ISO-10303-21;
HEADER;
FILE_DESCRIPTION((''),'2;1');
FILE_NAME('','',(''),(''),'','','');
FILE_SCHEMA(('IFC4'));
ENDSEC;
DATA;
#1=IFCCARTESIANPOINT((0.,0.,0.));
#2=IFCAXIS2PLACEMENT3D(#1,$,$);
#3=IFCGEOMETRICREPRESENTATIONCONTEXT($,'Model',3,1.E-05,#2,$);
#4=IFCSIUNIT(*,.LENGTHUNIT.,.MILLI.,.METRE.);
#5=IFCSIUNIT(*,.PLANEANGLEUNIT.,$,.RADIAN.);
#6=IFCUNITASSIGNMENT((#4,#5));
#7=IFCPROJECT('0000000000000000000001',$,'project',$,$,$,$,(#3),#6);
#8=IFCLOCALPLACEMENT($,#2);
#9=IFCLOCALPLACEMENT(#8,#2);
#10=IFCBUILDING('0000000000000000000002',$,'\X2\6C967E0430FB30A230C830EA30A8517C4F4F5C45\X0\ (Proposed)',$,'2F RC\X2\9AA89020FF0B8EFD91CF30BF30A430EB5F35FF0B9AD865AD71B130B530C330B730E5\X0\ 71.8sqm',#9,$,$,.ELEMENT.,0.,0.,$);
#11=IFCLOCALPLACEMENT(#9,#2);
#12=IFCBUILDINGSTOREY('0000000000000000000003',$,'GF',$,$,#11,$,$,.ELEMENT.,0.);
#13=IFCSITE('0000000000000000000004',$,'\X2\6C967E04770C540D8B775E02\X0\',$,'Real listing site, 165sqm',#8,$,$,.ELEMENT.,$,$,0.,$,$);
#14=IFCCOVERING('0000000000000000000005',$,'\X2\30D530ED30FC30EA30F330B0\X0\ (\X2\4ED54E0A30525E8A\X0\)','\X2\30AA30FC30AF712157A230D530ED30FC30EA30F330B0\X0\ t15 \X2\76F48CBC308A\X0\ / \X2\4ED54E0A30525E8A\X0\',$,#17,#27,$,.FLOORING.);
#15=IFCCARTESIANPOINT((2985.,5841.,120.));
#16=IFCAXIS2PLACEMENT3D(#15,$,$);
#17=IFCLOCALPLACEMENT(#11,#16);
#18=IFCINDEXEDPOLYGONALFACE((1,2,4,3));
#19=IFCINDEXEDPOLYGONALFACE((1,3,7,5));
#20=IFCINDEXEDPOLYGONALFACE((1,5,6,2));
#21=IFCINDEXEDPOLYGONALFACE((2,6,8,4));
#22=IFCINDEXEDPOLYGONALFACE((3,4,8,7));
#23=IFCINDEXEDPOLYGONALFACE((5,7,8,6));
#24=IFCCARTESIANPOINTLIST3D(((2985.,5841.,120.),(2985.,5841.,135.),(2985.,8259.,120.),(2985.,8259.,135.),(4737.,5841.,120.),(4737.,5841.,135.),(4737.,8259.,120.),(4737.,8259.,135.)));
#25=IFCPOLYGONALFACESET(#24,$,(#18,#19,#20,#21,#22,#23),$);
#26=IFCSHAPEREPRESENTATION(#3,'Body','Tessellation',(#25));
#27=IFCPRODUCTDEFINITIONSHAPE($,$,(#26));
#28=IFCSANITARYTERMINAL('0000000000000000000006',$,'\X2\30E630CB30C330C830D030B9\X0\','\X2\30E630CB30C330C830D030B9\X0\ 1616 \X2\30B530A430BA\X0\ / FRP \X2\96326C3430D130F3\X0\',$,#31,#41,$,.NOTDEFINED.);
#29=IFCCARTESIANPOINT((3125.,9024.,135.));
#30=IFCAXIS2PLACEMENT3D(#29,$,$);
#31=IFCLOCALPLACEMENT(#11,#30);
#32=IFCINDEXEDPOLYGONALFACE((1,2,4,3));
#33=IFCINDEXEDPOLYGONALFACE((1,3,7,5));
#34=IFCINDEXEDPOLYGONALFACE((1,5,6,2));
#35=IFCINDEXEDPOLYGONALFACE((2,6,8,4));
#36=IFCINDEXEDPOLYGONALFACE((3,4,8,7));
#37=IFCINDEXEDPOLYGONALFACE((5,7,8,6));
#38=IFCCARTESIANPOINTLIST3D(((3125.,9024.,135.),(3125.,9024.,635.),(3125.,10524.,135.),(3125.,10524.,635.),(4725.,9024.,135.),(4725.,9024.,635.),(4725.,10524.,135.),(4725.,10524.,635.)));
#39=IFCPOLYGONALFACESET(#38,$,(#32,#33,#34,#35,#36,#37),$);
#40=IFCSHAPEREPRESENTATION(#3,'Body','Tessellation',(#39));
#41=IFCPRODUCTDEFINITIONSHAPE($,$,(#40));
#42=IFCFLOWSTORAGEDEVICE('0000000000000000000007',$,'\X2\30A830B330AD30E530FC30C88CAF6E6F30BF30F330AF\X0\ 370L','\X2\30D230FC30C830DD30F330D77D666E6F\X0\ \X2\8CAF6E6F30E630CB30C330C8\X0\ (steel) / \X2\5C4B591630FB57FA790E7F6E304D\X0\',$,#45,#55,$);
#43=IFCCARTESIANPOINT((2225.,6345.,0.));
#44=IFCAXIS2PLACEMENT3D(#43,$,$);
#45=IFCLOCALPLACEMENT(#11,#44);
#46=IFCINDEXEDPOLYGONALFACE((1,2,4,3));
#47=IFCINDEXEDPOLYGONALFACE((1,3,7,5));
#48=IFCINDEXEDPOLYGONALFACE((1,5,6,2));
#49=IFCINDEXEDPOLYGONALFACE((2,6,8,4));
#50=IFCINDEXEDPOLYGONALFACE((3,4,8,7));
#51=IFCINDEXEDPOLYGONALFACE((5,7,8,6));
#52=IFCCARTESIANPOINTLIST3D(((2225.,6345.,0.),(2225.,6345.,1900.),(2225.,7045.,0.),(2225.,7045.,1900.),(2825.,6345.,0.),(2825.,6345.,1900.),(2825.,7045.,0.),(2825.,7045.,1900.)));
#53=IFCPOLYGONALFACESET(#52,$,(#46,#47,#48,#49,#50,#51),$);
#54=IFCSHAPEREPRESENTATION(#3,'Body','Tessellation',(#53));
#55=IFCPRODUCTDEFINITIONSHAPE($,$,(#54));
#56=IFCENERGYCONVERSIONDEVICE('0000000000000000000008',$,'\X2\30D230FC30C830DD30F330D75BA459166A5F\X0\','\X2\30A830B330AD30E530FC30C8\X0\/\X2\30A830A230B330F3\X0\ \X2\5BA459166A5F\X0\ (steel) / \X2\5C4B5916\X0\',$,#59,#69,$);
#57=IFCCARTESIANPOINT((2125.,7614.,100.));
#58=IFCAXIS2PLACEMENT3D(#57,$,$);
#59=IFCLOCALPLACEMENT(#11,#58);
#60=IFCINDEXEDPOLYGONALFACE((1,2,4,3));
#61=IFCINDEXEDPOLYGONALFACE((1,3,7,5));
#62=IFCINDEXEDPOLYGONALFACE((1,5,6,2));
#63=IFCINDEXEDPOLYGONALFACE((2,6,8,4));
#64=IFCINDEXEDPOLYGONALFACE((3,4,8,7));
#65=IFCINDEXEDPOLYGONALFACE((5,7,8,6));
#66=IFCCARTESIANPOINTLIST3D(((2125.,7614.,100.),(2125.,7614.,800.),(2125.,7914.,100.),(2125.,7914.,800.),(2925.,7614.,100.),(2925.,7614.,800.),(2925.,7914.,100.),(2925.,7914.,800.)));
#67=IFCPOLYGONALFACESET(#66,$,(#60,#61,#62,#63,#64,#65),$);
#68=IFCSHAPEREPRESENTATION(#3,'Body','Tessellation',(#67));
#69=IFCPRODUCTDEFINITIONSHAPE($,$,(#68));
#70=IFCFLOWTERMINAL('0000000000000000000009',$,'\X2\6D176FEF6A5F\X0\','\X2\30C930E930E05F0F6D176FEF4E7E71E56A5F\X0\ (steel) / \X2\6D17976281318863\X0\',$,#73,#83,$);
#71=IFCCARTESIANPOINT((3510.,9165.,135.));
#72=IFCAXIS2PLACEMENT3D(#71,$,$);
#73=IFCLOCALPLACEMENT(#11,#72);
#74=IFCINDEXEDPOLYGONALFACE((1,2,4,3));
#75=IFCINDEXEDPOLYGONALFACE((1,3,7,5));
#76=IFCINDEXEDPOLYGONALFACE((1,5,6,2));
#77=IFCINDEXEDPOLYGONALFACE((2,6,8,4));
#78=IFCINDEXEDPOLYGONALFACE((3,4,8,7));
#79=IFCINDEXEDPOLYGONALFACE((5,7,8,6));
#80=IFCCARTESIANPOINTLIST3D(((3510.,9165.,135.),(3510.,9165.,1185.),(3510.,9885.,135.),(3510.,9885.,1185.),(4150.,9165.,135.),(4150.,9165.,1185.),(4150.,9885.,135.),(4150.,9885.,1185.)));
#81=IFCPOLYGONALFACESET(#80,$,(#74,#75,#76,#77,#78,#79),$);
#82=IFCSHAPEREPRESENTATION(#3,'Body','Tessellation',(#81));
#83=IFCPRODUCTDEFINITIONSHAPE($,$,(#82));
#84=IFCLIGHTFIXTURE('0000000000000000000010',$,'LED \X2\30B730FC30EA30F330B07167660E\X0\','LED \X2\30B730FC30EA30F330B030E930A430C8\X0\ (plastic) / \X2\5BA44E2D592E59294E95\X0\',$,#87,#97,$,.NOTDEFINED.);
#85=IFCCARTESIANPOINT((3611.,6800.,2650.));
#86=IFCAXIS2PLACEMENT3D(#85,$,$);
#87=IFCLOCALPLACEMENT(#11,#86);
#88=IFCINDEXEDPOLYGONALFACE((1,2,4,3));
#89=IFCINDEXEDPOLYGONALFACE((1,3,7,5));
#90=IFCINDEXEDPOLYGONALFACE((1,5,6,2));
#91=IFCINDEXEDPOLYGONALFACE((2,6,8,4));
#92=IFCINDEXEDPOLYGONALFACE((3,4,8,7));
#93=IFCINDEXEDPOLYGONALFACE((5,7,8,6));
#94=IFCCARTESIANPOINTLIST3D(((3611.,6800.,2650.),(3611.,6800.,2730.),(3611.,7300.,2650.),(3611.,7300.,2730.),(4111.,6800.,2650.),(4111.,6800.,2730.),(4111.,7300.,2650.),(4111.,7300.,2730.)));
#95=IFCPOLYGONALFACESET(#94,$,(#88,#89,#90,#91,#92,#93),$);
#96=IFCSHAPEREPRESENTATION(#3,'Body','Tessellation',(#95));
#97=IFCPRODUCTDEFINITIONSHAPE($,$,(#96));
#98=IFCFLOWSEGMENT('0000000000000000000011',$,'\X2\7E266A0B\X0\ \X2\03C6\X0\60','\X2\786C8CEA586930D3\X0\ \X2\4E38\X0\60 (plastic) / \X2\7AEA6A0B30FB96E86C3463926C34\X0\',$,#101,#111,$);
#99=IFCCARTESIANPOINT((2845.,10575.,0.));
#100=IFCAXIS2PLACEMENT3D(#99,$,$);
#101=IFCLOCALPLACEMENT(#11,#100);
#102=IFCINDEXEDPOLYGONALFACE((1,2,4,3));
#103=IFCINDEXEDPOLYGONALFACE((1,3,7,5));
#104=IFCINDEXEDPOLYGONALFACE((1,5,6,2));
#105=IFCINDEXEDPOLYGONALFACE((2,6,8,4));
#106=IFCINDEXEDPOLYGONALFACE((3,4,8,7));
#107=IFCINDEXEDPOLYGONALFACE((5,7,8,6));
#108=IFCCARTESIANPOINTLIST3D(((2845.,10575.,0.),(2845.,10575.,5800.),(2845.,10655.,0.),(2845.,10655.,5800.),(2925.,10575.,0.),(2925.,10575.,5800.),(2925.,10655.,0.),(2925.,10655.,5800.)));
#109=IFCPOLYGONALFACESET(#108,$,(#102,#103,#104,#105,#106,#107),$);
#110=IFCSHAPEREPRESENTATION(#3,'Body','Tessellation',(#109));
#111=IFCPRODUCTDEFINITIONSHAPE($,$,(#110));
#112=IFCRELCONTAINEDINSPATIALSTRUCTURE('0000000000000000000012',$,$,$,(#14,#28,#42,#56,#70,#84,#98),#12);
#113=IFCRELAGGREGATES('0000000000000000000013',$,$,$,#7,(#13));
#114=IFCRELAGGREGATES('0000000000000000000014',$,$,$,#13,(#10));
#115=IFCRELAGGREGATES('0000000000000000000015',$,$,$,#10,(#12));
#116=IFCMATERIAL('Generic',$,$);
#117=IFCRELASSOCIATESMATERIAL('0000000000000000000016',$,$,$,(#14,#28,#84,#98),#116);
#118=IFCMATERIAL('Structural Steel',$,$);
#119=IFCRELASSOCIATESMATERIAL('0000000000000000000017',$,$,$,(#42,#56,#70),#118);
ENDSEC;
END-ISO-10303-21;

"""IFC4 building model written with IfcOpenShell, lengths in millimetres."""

from ifc_helpers import new_model, si_unit, frame, frame_2d, origin, place, context, project, spatial, rectangle, extrude, material, element, save


model = new_model("IFC4")

# Units and contexts
model_context = context("Model", 3, precision=1e-05, world=origin())
ifc_project = project(units=[si_unit("LENGTHUNIT", "METRE", prefix="MILLI"), si_unit("PLANEANGLEUNIT", "RADIAN")], contexts=[model_context])

# Site, building, storey
site_placement = place(None, origin())
site = spatial("IfcSite", under=ifc_project, at=site_placement, Name="沖縄県名護市", ObjectType="Real listing site, 165sqm", CompositionType="ELEMENT", RefElevation=0.0)
building_placement = place(site_placement, origin())
building = spatial("IfcBuilding", under=site, at=building_placement, Name="沖縄・アトリエ兼住居 (Proposed)", ObjectType="2F RC骨造＋軽量タイル張＋高断熱サッシュ 71.8sqm", CompositionType="ELEMENT", ElevationOfRefHeight=0.0, ElevationOfTerrain=0.0)
storey_placement = place(building_placement, origin())
storey = spatial("IfcBuildingStorey", under=building, at=storey_placement, Name="GF", CompositionType="ELEMENT", Elevation=0.0)

# Covering
ifc_material_1 = material(Name="Generic")
covering_1_placement = place(storey_placement, frame((2985.0, 5841.0, 120.0)))
element("IfcCovering", 1, at=covering_1_placement, inside=storey, material=ifc_material_1, Name="フローリング (仕上げ床)", Description="オーク無垢フローリング t15 直貼り / 仕上げ床", PredefinedType="FLOORING", context=model_context, shape_type="SweptSolid", body=[
    extrude(rectangle(XDim=1752.0, YDim=2418.0, at=frame_2d((876.0, 1209.0))), frame((2985.0, 5841.0, 120.0)), (0.0, 0.0, 1.0), 15.0),
])

# Sanitary terminal
sanitary_terminal_placement = place(storey_placement, frame((3125.0, 9024.0, 135.0)))
element("IfcSanitaryTerminal", 2, at=sanitary_terminal_placement, inside=storey, material=ifc_material_1, Name="ユニットバス", Description="ユニットバス 1616 サイズ / FRP 防水パン", PredefinedType="NOTDEFINED", context=model_context, shape_type="SweptSolid", body=[
    extrude(rectangle(XDim=1600.0, YDim=1500.0, at=frame_2d((800.0, 750.0))), frame((3125.0, 9024.0, 135.0)), (0.0, 0.0, 1.0), 500.0),
])

# Flow storage device
ifc_material_2 = material(Name="Structural Steel")
flow_storage_device_placement = place(storey_placement, frame((2225.0, 6345.0, 0.0)))
element("IfcFlowStorageDevice", 3, at=flow_storage_device_placement, inside=storey, material=ifc_material_2, Name="エコキュート貯湯タンク 370L", Description="ヒートポンプ給湯 貯湯ユニット (steel) / 屋外・基礎置き", context=model_context, shape_type="SweptSolid", body=[
    extrude(rectangle(XDim=600.0, YDim=700.0, at=frame_2d((300.0, 350.0))), frame((2225.0, 6345.0, 0.0)), (0.0, 0.0, 1.0), 1900.0),
])

# Energy conversion device
energy_conversion_device_placement = place(storey_placement, frame((2125.0, 7614.0, 100.0)))
element("IfcEnergyConversionDevice", 4, at=energy_conversion_device_placement, inside=storey, material=ifc_material_2, Name="ヒートポンプ室外機", Description="エコキュート/エアコン 室外機 (steel) / 屋外", context=model_context, shape_type="SweptSolid", body=[
    extrude(rectangle(XDim=800.0, YDim=300.0, at=frame_2d((400.0, 150.0))), frame((2125.0, 7614.0, 100.0)), (0.0, 0.0, 1.0), 700.0),
])

# Flow terminal
flow_terminal_placement = place(storey_placement, frame((3510.0, 9165.0, 135.0)))
element("IfcFlowTerminal", 5, at=flow_terminal_placement, inside=storey, material=ifc_material_2, Name="洗濯機", Description="ドラム式洗濯乾燥機 (steel) / 洗面脱衣", context=model_context, shape_type="SweptSolid", body=[
    extrude(rectangle(XDim=640.0, YDim=720.0, at=frame_2d((320.0, 360.0))), frame((3510.0, 9165.0, 135.0)), (0.0, 0.0, 1.0), 1050.0),
])

# Light fixture
light_fixture_placement = place(storey_placement, frame((3611.0, 6800.0, 2650.0)))
element("IfcLightFixture", 6, at=light_fixture_placement, inside=storey, material=ifc_material_1, Name="LED シーリング照明", Description="LED シーリングライト (plastic) / 室中央天井", PredefinedType="NOTDEFINED", context=model_context, shape_type="SweptSolid", body=[
    extrude(rectangle(XDim=500.0, YDim=500.0, at=frame_2d((250.0, 250.0))), frame((3611.0, 6800.0, 2650.0)), (0.0, 0.0, 1.0), 80.0),
])

# Flow segment
flow_segment_placement = place(storey_placement, frame((2845.0, 10575.0, 0.0)))
element("IfcFlowSegment", 7, at=flow_segment_placement, inside=storey, material=ifc_material_1, Name="縦樋 φ60", Description="硬質塩ビ 丸60 (plastic) / 竪樋・雨水排水", context=model_context, shape_type="SweptSolid", body=[
    extrude(rectangle(XDim=80.0, YDim=80.0, at=frame_2d((40.0, 40.0))), frame((2845.0, 10575.0, 0.0)), (0.0, 0.0, 1.0), 5800.0),
])

save(model, "model.ifc")
